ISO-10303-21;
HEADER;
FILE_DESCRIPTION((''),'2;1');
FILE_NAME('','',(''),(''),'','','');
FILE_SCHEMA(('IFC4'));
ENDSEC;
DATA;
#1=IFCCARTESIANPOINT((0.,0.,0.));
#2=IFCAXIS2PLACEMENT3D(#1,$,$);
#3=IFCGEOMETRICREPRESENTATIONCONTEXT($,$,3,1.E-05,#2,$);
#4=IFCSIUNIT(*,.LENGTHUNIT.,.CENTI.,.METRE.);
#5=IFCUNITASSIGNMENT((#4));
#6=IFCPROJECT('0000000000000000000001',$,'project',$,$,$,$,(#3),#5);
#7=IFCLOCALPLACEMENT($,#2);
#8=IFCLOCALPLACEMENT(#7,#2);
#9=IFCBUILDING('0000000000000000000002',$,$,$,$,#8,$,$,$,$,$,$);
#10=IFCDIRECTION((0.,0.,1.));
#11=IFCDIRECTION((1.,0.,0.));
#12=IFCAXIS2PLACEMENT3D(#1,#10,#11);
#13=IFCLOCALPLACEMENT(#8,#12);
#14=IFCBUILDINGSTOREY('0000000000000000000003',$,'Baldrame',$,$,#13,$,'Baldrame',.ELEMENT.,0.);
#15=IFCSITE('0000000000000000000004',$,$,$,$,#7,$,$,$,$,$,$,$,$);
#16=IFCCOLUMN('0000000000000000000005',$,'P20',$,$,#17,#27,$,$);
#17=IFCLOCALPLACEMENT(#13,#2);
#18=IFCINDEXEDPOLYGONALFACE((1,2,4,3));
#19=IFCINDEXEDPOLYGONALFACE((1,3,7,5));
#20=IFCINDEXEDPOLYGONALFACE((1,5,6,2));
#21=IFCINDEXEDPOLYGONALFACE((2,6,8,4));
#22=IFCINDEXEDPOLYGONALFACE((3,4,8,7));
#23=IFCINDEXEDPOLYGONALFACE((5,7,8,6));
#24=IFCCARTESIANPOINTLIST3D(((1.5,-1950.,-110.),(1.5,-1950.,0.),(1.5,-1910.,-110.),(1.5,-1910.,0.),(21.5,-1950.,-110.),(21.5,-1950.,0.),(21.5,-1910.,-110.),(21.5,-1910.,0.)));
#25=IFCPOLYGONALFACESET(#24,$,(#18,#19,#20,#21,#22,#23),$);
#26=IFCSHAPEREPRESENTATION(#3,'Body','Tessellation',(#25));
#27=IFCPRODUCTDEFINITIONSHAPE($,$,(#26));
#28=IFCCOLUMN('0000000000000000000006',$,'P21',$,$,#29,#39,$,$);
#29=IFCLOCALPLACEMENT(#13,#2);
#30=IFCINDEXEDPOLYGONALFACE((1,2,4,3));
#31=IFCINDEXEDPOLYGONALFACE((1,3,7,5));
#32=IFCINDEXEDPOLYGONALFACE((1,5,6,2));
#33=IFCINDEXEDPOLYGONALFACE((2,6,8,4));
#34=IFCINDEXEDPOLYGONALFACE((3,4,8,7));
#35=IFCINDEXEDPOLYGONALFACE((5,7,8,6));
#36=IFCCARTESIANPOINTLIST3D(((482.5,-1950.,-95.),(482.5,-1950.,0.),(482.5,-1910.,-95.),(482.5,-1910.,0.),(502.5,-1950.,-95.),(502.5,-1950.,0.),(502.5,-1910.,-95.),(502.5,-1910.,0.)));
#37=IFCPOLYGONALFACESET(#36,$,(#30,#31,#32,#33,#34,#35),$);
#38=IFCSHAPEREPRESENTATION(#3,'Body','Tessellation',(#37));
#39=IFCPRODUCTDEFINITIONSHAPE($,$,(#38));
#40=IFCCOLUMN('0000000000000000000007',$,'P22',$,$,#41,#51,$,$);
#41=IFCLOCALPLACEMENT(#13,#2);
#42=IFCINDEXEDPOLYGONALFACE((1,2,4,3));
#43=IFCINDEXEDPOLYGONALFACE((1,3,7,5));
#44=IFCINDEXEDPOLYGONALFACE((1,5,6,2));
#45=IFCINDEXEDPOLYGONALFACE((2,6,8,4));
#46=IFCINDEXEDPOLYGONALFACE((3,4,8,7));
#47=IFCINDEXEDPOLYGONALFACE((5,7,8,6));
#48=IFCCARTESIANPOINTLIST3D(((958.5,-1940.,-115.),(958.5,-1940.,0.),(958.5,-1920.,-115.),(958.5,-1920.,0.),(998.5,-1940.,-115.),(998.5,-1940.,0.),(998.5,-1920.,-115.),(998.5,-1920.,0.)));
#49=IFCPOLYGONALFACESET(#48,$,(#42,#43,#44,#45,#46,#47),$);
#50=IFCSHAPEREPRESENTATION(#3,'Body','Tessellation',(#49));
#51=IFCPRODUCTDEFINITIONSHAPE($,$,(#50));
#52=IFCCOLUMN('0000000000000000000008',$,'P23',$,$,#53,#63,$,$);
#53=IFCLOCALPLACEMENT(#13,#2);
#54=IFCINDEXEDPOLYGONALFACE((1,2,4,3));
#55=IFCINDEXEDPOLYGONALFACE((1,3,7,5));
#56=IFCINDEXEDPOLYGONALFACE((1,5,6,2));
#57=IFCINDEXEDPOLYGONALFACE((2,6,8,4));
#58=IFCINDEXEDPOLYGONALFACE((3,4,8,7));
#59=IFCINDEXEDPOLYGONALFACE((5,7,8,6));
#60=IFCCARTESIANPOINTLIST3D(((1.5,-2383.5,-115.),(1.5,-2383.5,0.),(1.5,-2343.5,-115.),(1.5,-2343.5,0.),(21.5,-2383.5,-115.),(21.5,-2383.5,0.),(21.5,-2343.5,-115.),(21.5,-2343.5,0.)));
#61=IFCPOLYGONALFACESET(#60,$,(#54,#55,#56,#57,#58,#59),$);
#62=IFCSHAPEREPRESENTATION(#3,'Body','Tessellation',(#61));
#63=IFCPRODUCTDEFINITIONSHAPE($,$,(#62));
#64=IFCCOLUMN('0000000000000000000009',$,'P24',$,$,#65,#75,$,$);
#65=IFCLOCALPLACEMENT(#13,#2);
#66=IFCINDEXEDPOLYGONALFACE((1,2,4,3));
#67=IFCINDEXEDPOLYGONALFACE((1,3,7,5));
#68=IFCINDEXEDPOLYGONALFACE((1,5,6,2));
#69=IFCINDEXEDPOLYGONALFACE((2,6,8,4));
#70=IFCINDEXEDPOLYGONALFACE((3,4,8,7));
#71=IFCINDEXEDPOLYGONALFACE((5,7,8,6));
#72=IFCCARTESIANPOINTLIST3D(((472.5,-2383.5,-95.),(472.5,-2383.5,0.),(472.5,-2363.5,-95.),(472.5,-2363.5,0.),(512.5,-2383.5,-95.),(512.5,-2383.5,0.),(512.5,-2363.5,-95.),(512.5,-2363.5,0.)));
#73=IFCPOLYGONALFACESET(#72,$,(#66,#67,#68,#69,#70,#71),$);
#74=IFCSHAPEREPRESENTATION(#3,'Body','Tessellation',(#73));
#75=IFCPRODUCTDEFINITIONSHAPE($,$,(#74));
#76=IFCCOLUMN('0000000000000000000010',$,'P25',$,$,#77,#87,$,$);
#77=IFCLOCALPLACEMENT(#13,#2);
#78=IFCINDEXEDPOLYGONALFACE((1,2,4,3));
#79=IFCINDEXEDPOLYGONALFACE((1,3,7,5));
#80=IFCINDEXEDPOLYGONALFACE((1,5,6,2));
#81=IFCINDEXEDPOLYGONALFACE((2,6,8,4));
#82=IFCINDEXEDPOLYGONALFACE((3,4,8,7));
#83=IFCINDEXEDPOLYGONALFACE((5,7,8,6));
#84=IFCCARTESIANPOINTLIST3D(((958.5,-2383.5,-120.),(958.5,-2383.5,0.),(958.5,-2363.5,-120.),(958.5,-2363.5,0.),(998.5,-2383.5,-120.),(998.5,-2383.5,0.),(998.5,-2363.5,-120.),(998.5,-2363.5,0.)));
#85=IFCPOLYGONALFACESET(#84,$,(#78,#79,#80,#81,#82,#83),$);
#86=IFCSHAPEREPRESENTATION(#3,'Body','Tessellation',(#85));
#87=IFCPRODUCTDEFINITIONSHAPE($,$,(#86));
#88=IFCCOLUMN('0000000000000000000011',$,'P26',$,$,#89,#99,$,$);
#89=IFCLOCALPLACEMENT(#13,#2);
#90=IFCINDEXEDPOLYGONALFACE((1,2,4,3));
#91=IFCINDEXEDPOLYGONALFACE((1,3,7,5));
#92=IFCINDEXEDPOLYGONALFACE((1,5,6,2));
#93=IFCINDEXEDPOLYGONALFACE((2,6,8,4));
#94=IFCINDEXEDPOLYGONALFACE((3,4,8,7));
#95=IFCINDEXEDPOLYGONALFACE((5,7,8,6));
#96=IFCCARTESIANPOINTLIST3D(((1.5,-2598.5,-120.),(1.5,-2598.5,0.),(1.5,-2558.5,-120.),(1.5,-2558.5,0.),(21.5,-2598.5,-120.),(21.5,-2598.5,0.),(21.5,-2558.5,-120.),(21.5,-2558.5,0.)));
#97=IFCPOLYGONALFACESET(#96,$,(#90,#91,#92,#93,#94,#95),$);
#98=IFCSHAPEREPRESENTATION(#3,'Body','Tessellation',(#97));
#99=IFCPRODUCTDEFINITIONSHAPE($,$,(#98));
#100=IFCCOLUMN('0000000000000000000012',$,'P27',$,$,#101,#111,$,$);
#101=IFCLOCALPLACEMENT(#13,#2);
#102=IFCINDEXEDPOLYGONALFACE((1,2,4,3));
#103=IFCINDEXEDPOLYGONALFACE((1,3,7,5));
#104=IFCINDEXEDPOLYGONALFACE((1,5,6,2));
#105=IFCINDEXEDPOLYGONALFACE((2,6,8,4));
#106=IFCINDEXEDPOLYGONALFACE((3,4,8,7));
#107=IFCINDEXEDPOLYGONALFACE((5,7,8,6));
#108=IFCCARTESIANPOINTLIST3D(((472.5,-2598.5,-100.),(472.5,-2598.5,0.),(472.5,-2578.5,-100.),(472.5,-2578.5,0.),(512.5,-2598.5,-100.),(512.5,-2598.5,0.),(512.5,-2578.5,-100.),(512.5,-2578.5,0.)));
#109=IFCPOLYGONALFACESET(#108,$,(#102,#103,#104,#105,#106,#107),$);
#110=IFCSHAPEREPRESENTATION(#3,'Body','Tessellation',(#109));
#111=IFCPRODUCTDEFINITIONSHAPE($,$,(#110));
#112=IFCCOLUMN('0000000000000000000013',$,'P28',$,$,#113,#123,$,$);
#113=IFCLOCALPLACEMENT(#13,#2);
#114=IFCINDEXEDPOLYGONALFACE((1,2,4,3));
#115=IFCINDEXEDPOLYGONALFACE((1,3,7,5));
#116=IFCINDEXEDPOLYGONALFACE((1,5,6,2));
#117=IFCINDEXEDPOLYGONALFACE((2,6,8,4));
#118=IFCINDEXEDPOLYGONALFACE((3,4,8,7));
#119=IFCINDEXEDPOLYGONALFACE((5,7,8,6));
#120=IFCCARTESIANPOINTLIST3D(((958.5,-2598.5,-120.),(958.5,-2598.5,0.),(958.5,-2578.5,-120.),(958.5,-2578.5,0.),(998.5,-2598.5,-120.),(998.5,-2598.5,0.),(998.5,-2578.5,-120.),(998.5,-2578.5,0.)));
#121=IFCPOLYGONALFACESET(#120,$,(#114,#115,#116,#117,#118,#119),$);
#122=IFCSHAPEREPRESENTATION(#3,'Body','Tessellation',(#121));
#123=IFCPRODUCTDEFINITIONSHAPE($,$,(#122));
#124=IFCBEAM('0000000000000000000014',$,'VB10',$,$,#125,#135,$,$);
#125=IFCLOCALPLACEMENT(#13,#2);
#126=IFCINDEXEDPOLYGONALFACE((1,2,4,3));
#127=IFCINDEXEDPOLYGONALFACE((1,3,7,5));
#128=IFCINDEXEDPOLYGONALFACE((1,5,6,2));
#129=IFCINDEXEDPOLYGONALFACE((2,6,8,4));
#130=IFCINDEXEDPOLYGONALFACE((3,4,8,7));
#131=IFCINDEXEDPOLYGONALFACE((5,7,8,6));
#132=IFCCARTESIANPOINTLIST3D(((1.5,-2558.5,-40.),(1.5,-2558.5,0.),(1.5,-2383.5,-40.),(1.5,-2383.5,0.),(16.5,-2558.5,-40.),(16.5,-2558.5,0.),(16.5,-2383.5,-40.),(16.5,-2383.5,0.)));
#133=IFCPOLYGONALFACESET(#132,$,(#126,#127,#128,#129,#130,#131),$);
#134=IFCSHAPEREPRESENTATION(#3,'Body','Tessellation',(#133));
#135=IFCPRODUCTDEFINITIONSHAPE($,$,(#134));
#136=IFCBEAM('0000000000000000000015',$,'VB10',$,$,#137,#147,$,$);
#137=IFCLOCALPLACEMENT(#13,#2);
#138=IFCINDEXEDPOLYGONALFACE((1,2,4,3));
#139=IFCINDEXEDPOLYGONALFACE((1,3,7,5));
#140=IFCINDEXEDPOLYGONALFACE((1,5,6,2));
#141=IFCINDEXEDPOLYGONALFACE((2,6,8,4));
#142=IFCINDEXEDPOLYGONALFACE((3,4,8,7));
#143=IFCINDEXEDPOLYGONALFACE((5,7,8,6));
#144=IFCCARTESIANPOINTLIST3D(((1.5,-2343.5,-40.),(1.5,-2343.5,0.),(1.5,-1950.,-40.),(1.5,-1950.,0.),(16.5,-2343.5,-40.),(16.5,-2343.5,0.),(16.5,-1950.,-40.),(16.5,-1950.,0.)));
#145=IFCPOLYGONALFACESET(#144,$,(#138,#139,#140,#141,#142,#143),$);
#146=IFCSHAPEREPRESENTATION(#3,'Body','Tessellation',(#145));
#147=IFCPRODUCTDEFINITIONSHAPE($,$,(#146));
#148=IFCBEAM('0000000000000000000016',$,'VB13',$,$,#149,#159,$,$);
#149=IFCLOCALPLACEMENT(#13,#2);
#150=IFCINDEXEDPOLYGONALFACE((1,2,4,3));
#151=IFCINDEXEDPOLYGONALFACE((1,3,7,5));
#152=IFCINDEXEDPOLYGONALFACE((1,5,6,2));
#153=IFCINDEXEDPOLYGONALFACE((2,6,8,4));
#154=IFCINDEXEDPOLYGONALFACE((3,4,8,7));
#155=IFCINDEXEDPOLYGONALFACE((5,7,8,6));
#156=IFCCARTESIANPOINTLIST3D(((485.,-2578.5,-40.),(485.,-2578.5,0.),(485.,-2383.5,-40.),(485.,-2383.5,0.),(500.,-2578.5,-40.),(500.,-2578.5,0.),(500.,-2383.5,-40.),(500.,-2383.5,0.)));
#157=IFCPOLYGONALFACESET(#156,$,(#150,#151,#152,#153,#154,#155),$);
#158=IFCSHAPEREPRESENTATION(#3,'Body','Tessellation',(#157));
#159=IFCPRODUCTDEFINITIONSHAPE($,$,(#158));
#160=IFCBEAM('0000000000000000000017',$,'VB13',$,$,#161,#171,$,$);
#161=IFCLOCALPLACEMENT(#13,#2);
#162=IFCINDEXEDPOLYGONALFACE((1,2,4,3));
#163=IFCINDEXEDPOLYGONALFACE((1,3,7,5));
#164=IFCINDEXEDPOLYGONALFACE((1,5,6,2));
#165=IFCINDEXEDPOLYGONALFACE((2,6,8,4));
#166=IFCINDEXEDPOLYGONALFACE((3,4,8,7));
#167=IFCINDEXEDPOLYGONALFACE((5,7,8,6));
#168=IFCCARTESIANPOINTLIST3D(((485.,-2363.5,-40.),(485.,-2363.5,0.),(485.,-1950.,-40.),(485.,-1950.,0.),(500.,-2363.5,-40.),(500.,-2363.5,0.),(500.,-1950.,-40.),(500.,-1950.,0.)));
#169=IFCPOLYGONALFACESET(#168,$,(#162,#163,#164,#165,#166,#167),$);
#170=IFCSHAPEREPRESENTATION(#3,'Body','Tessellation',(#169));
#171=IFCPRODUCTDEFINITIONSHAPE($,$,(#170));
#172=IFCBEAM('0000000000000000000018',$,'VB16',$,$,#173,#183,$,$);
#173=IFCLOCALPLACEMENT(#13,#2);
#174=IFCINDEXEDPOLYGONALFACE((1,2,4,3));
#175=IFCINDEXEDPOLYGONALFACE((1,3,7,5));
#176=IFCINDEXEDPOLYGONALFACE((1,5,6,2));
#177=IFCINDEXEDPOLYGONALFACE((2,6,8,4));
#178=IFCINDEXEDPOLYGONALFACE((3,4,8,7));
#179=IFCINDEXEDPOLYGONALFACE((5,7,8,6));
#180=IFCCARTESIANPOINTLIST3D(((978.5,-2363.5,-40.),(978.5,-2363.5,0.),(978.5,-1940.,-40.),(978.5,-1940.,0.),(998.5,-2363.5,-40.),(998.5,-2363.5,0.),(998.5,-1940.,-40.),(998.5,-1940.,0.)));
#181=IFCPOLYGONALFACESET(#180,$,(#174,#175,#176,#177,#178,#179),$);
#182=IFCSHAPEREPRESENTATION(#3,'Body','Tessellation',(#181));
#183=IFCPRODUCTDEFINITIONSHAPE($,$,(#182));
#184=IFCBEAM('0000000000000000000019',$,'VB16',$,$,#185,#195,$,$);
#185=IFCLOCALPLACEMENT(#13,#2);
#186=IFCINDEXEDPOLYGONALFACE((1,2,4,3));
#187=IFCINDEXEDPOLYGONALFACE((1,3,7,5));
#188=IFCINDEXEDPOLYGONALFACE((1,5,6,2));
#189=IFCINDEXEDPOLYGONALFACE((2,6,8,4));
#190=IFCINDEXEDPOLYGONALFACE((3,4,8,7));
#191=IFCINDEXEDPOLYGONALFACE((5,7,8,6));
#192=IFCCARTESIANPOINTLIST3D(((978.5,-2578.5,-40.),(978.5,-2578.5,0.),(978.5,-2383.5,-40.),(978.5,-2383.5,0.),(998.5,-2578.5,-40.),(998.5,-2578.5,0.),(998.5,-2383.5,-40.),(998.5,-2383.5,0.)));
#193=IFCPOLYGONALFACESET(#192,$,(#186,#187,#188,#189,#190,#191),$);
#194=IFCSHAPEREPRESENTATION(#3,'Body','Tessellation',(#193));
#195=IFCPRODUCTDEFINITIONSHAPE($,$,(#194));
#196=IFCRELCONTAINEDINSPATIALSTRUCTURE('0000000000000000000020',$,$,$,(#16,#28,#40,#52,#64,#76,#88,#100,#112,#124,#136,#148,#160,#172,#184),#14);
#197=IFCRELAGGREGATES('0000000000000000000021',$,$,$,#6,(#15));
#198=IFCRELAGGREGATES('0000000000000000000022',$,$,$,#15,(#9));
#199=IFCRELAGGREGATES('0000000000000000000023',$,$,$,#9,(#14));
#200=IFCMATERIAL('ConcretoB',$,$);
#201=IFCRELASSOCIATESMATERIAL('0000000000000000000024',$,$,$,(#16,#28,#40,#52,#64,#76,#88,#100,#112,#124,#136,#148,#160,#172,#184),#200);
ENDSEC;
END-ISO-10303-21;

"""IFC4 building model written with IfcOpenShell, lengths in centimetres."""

from ifc_helpers import new_model, si_unit, frame, origin, origin_with_axes, place, context, project, spatial, polyline, outline, extrude, material, element, save


model = new_model("IFC4")

# Units and contexts
context_of_model = context(None, 3, precision=1e-05, world=origin())
ifc_project = project(units=[si_unit("LENGTHUNIT", "METRE", prefix="CENTI")], contexts=[context_of_model])

# Site, building, storey
site_placement = place(None, origin())
site = spatial("IfcSite", under=ifc_project, at=site_placement)
building_placement = place(site_placement, origin())
building = spatial("IfcBuilding", under=site, at=building_placement)
storey_placement = place(building_placement, origin_with_axes())
storey = spatial("IfcBuildingStorey", under=building, at=storey_placement, Name="Baldrame", LongName="Baldrame", CompositionType="ELEMENT", Elevation=0.0)

# Columns
ifc_material = material(Name="ConcretoB")
column_1_placement = place(storey_placement, frame((11.5, -1930.0, 0.0), z_axis=(0.0, 0.0, 1.0), x_axis=(1.0, 0.0, 0.0)))
element("IfcColumn", 1, at=column_1_placement, inside=storey, material=ifc_material, Name="P20", context=context_of_model, shape_type="SolidModel", body=[
    extrude(outline(polyline([(-10.0, -20.0), (10.0, -20.0), (10.0, 20.0), (-10.0, 20.0), (-10.0, -20.0)])), frame((0.0, 0.0, -110.0), z_axis=(0.0, 0.0, 1.0), x_axis=(1.0, 0.0, 0.0)), (0.0, 0.0, 1.0), 110.0),
])
column_2_placement = place(storey_placement, frame((492.5, -1930.0, 0.0), z_axis=(0.0, 0.0, 1.0), x_axis=(1.0, 0.0, 0.0)))
element("IfcColumn", 2, at=column_2_placement, inside=storey, material=ifc_material, Name="P21", context=context_of_model, shape_type="SolidModel", body=[
    extrude(outline(polyline([(-10.0, -20.0), (10.0, -20.0), (10.0, 20.0), (-10.0, 20.0), (-10.0, -20.0)])), frame((0.0, 0.0, -95.0), z_axis=(0.0, 0.0, 1.0), x_axis=(1.0, 0.0, 0.0)), (0.0, 0.0, 1.0), 95.0),
])
column_3_placement = place(storey_placement, frame((978.5, -1930.0, 0.0), z_axis=(0.0, 0.0, 1.0), x_axis=(1.0, 0.0, 0.0)))
element("IfcColumn", 3, at=column_3_placement, inside=storey, material=ifc_material, Name="P22", context=context_of_model, shape_type="SolidModel", body=[
    extrude(outline(polyline([(-20.0, 10.0), (-20.0, -10.0), (20.0, -10.0), (20.0, 10.0), (-20.0, 10.0)])), frame((0.0, 0.0, -115.0), z_axis=(0.0, 0.0, 1.0), x_axis=(1.0, 0.0, 0.0)), (0.0, 0.0, 1.0), 115.0),
])
column_4_placement = place(storey_placement, frame((11.5, -2363.5, 0.0), z_axis=(0.0, 0.0, 1.0), x_axis=(1.0, 0.0, 0.0)))
element("IfcColumn", 4, at=column_4_placement, inside=storey, material=ifc_material, Name="P23", context=context_of_model, shape_type="SolidModel", body=[
    extrude(outline(polyline([(-10.0, -20.0), (10.0, -20.0), (10.0, 20.0), (-10.0, 20.0), (-10.0, -20.0)])), frame((0.0, 0.0, -115.0), z_axis=(0.0, 0.0, 1.0), x_axis=(1.0, 0.0, 0.0)), (0.0, 0.0, 1.0), 115.0),
])
column_5_placement = place(storey_placement, frame((492.5, -2373.5, 0.0), z_axis=(0.0, 0.0, 1.0), x_axis=(1.0, 0.0, 0.0)))
element("IfcColumn", 5, at=column_5_placement, inside=storey, material=ifc_material, Name="P24", context=context_of_model, shape_type="SolidModel", body=[
    extrude(outline(polyline([(-20.0, 10.0), (-20.0, -10.0), (20.0, -10.0), (20.0, 10.0), (-20.0, 10.0)])), frame((0.0, 0.0, -95.0), z_axis=(0.0, 0.0, 1.0), x_axis=(1.0, 0.0, 0.0)), (0.0, 0.0, 1.0), 95.0),
])
column_6_placement = place(storey_placement, frame((978.5, -2373.5, 0.0), z_axis=(0.0, 0.0, 1.0), x_axis=(1.0, 0.0, 0.0)))
element("IfcColumn", 6, at=column_6_placement, inside=storey, material=ifc_material, Name="P25", context=context_of_model, shape_type="SolidModel", body=[
    extrude(outline(polyline([(-20.0, 10.0), (-20.0, -10.0), (20.0, -10.0), (20.0, 10.0), (-20.0, 10.0)])), frame((0.0, 0.0, -120.0), z_axis=(0.0, 0.0, 1.0), x_axis=(1.0, 0.0, 0.0)), (0.0, 0.0, 1.0), 120.0),
])
column_7_placement = place(storey_placement, frame((11.5, -2578.5, 0.0), z_axis=(0.0, 0.0, 1.0), x_axis=(1.0, 0.0, 0.0)))
element("IfcColumn", 7, at=column_7_placement, inside=storey, material=ifc_material, Name="P26", context=context_of_model, shape_type="SolidModel", body=[
    extrude(outline(polyline([(-10.0, -20.0), (10.0, -20.0), (10.0, 20.0), (-10.0, 20.0), (-10.0, -20.0)])), frame((0.0, 0.0, -120.0), z_axis=(0.0, 0.0, 1.0), x_axis=(1.0, 0.0, 0.0)), (0.0, 0.0, 1.0), 120.0),
])
column_8_placement = place(storey_placement, frame((492.5, -2588.5, 0.0), z_axis=(0.0, 0.0, 1.0), x_axis=(1.0, 0.0, 0.0)))
element("IfcColumn", 8, at=column_8_placement, inside=storey, material=ifc_material, Name="P27", context=context_of_model, shape_type="SolidModel", body=[
    extrude(outline(polyline([(20.0, -10.0), (20.0, 10.0), (-20.0, 10.0), (-20.0, -10.0), (20.0, -10.0)])), frame((0.0, 0.0, -100.0), z_axis=(0.0, 0.0, 1.0), x_axis=(1.0, 0.0, 0.0)), (0.0, 0.0, 1.0), 100.0),
])
column_9_placement = place(storey_placement, frame((978.5, -2588.5, 0.0), z_axis=(0.0, 0.0, 1.0), x_axis=(1.0, 0.0, 0.0)))
element("IfcColumn", 9, at=column_9_placement, inside=storey, material=ifc_material, Name="P28", context=context_of_model, shape_type="SolidModel", body=[
    extrude(outline(polyline([(-20.0, 10.0), (-20.0, -10.0), (20.0, -10.0), (20.0, 10.0), (-20.0, 10.0)])), frame((0.0, 0.0, -120.0), z_axis=(0.0, 0.0, 1.0), x_axis=(1.0, 0.0, 0.0)), (0.0, 0.0, 1.0), 120.0),
])

# Beams
beam_1_placement = place(storey_placement, frame((9.0, -2471.0, 0.0), z_axis=(0.0, 0.0, 1.0), x_axis=(1.0, 0.0, 0.0)))
element("IfcBeam", 10, at=beam_1_placement, inside=storey, material=ifc_material, Name="VB10", context=context_of_model, shape_type="SolidModel", body=[
    extrude(outline(polyline([(-7.5, -20.0), (7.5, -20.0), (7.5, 20.0), (-7.5, 20.0), (-7.5, -20.0)])), frame((0.0, -87.5, -20.0), z_axis=(0.0, 1.0, 0.0), x_axis=(1.0, 0.0, 0.0)), (0.0, 0.0, 1.0), 175.0),
])
beam_2_placement = place(storey_placement, frame((9.0, -2146.75, 0.0), z_axis=(0.0, 0.0, 1.0), x_axis=(1.0, 0.0, 0.0)))
element("IfcBeam", 11, at=beam_2_placement, inside=storey, material=ifc_material, Name="VB10", context=context_of_model, shape_type="SolidModel", body=[
    extrude(outline(polyline([(-7.5, -20.0), (7.5, -20.0), (7.5, 20.0), (-7.5, 20.0), (-7.5, -20.0)])), frame((0.0, -196.75, -20.0), z_axis=(0.0, 1.0, 0.0), x_axis=(1.0, 0.0, 0.0)), (0.0, 0.0, 1.0), 393.5),
])
beam_3_placement = place(storey_placement, frame((492.5, -2481.0, 0.0), z_axis=(0.0, 0.0, 1.0), x_axis=(1.0, 0.0, 0.0)))
element("IfcBeam", 12, at=beam_3_placement, inside=storey, material=ifc_material, Name="VB13", context=context_of_model, shape_type="SolidModel", body=[
    extrude(outline(polyline([(-7.5, -20.0), (7.5, -20.0), (7.5, 20.0), (-7.5, 20.0), (-7.5, -20.0)])), frame((0.0, -97.5, -20.0), z_axis=(0.0, 1.0, 0.0), x_axis=(1.0, 0.0, 0.0)), (0.0, 0.0, 1.0), 195.0),
])
beam_4_placement = place(storey_placement, frame((492.5, -2156.75, 0.0), z_axis=(0.0, 0.0, 1.0), x_axis=(1.0, 0.0, 0.0)))
element("IfcBeam", 13, at=beam_4_placement, inside=storey, material=ifc_material, Name="VB13", context=context_of_model, shape_type="SolidModel", body=[
    extrude(outline(polyline([(-7.5, -20.0), (7.5, -20.0), (7.5, 20.0), (-7.5, 20.0), (-7.5, -20.0)])), frame((0.0, -206.75, -20.0), z_axis=(0.0, 1.0, 0.0), x_axis=(1.0, 0.0, 0.0)), (0.0, 0.0, 1.0), 413.5),
])
beam_5_placement = place(storey_placement, frame((988.5, -2151.75, 0.0), z_axis=(0.0, 0.0, 1.0), x_axis=(1.0, 0.0, 0.0)))
element("IfcBeam", 14, at=beam_5_placement, inside=storey, material=ifc_material, Name="VB16", context=context_of_model, shape_type="SolidModel", body=[
    extrude(outline(polyline([(-10.0, -20.0), (10.0, -20.0), (10.0, 20.0), (-10.0, 20.0), (-10.0, -20.0)])), frame((0.0, -211.75, -20.0), z_axis=(0.0, 1.0, 0.0), x_axis=(1.0, 0.0, 0.0)), (0.0, 0.0, 1.0), 423.5),
])
beam_6_placement = place(storey_placement, frame((988.5, -2481.0, 0.0), z_axis=(0.0, 0.0, 1.0), x_axis=(1.0, 0.0, 0.0)))
element("IfcBeam", 15, at=beam_6_placement, inside=storey, material=ifc_material, Name="VB16", context=context_of_model, shape_type="SolidModel", body=[
    extrude(outline(polyline([(-10.0, -20.0), (10.0, -20.0), (10.0, 20.0), (-10.0, 20.0), (-10.0, -20.0)])), frame((0.0, -97.5, -20.0), z_axis=(0.0, 1.0, 0.0), x_axis=(1.0, 0.0, 0.0)), (0.0, 0.0, 1.0), 195.0),
])

save(model, "model.ifc")
